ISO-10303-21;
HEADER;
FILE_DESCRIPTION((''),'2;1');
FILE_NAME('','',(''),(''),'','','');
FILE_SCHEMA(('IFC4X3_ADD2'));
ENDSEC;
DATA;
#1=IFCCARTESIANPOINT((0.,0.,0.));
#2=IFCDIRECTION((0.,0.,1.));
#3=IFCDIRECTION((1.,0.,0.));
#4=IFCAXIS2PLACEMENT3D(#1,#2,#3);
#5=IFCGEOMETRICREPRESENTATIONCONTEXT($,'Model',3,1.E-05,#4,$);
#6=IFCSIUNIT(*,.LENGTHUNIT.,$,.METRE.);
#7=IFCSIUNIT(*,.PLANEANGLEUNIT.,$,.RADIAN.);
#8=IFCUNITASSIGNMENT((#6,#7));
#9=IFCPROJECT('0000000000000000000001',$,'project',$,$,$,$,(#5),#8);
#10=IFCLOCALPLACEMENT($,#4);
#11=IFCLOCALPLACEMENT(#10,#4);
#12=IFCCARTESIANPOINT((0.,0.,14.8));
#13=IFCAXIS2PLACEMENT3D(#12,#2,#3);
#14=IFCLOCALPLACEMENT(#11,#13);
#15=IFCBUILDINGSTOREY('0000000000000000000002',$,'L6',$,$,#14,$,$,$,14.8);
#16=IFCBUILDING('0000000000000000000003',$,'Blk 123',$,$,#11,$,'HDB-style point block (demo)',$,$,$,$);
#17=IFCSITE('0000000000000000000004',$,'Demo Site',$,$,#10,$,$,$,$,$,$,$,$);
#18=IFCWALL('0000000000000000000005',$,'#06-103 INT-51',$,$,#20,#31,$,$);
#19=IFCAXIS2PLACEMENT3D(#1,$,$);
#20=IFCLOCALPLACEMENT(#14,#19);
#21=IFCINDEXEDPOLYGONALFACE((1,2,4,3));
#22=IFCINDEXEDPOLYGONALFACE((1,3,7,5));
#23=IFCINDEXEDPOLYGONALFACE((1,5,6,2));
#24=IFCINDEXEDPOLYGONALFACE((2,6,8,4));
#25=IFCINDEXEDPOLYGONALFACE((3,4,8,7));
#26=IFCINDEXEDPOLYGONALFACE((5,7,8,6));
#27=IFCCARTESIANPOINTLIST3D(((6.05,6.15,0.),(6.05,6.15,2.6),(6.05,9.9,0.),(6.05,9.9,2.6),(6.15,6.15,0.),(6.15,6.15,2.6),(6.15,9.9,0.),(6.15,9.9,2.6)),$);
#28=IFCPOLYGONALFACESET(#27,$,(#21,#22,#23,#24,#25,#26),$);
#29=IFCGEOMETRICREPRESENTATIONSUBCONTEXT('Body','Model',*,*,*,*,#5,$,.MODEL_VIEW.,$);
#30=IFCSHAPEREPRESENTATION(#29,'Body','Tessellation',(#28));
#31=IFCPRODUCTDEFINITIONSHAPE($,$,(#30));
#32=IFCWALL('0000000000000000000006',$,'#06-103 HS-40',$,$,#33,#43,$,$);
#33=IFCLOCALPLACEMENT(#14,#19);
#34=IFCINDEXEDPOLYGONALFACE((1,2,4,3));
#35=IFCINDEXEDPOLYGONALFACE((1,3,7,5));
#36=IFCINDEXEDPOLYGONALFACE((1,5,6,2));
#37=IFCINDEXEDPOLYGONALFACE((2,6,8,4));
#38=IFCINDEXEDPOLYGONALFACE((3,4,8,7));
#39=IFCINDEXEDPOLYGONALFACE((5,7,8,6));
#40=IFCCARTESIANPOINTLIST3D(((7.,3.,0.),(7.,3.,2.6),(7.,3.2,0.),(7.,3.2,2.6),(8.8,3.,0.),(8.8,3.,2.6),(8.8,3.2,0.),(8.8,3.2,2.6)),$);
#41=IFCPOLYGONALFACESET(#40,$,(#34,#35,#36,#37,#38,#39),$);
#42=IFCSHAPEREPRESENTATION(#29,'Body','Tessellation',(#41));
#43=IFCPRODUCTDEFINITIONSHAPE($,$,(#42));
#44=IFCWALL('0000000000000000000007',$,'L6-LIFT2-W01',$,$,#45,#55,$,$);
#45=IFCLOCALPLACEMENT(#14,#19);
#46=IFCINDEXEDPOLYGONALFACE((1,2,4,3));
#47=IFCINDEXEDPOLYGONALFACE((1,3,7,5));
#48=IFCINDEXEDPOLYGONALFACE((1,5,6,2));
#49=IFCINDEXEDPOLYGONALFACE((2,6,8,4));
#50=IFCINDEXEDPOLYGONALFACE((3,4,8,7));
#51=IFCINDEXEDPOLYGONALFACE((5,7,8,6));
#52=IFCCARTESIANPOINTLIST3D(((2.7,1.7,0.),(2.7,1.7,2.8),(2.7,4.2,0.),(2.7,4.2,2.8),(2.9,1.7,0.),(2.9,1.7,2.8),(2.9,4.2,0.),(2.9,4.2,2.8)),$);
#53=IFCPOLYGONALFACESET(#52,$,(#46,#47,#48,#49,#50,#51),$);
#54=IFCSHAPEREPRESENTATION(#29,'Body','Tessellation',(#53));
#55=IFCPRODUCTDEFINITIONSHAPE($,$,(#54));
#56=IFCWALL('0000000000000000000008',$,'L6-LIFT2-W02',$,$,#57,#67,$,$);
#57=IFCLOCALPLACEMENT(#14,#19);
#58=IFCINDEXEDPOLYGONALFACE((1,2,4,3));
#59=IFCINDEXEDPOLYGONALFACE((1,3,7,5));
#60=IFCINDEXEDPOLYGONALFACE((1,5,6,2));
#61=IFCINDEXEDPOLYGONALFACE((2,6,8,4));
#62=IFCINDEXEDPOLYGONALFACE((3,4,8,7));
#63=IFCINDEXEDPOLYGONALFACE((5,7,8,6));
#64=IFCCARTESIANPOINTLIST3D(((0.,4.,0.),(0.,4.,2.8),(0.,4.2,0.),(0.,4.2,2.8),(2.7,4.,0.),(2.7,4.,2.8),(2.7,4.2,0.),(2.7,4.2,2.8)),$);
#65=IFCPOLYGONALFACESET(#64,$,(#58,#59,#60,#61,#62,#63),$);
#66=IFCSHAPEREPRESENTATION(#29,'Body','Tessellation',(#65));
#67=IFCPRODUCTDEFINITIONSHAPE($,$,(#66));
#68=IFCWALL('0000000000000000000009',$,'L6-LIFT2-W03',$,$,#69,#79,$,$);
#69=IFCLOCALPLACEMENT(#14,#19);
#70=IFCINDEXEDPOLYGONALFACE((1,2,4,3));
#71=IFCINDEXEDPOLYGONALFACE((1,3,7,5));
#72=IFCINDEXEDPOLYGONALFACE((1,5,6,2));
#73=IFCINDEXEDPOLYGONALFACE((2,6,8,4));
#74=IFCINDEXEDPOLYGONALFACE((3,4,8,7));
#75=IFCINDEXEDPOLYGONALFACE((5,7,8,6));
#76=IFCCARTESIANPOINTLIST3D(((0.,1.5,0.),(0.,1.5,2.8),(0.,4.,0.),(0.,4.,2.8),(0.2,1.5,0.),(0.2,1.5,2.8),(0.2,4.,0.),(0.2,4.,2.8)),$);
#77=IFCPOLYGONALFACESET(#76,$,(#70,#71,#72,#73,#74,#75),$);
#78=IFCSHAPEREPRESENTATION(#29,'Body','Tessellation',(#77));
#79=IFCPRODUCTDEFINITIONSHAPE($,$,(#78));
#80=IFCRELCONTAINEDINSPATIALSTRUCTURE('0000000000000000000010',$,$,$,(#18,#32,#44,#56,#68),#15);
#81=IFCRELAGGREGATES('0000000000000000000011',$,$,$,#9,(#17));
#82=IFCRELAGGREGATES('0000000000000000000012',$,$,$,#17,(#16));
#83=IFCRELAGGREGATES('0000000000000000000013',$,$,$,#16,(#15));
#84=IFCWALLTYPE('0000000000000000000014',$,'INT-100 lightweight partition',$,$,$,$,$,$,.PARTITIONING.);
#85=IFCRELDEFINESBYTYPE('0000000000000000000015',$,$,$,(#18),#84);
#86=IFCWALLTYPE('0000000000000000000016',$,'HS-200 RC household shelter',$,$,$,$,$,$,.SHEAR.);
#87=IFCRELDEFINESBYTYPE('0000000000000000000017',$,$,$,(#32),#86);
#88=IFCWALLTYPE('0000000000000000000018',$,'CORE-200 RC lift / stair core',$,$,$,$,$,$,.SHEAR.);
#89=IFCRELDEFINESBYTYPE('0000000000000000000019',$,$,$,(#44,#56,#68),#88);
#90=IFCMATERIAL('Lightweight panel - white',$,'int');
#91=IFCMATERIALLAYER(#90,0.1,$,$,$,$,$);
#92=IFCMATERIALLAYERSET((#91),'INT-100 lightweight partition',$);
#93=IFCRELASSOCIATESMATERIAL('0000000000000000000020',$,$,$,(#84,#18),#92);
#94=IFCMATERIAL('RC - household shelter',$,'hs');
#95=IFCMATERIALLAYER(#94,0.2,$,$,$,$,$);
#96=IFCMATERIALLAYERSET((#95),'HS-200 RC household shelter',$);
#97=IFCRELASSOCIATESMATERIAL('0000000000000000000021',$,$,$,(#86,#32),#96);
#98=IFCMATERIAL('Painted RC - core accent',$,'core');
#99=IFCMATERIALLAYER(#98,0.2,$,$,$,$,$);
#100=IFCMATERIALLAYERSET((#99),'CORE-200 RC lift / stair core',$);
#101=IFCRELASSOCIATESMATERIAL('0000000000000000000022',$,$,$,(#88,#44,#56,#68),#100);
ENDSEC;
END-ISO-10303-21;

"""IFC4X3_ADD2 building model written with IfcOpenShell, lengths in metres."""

from ifc_helpers import new_model, si_unit, frame, origin_with_axes, place, context, subcontext, project, spatial, indexed_curve, outline, extrude, material, layer, layer_set, layer_usage, type_object, element, save


model = new_model("IFC4X3_ADD2")

# Units and contexts
model_context = context("Model", 3, precision=1e-05, world=origin_with_axes())
body_context = subcontext(model_context, "Body", "Model", "MODEL_VIEW")
ifc_project = project(units=[si_unit("LENGTHUNIT", "METRE"), si_unit("PLANEANGLEUNIT", "RADIAN")], contexts=[model_context])

# Site, building, storey
site_placement = place(None, origin_with_axes())
site = spatial("IfcSite", under=ifc_project, at=site_placement, Name="Demo Site")
building_placement = place(site_placement, origin_with_axes())
building = spatial("IfcBuilding", under=site, at=building_placement, Name="Blk 123", LongName="HDB-style point block (demo)")
storey_placement = place(building_placement, frame((0.0, 0.0, 14.8), z_axis=(0.0, 0.0, 1.0), x_axis=(1.0, 0.0, 0.0)))
storey = spatial("IfcBuildingStorey", under=building, at=storey_placement, Name="L6", Elevation=14.8)

# Shared definitions
ifc_material_1 = material(Name="Lightweight panel - white", Category="int")
ifc_layer_1 = layer(ifc_material_1, 0.1)
ifc_layer_set_1 = layer_set([ifc_layer_1], Name="INT-100 lightweight partition")
ifc_layer_usage_1 = layer_usage(ifc_layer_set_1, "AXIS2", "POSITIVE", -0.05)
wall_type_1 = type_object("IfcWallType", Name="INT-100 lightweight partition", PredefinedType="PARTITIONING", material=ifc_layer_set_1)

# Walls
wall_1_placement = place(storey_placement, frame((6.1, 6.15, 0.0), z_axis=(0.0, 0.0, 1.0), x_axis=(0.0, 1.0, 0.0)))
element("IfcWall", 1, at=wall_1_placement, inside=storey, type_object=wall_type_1, material=ifc_layer_usage_1, Name="#06-103 INT-51", context=body_context, shape_type="SweptSolid", body=[
    extrude(outline(indexed_curve([(0.0, 0.0), (0.0, 0.1), (3.75, 0.1), (3.75, 0.0), (0.0, 0.0)], self_intersect=False)), frame((0.0, -0.05, 0.0), z_axis=(0.0, 0.0, 1.0), x_axis=(1.0, 0.0, 0.0)), (0.0, 0.0, 1.0), 2.6),
])
ifc_material_2 = material(Name="RC - household shelter", Category="hs")
ifc_layer_2 = layer(ifc_material_2, 0.2)
ifc_layer_set_2 = layer_set([ifc_layer_2], Name="HS-200 RC household shelter")
ifc_layer_usage_2 = layer_usage(ifc_layer_set_2, "AXIS2", "POSITIVE", -0.1)
wall_type_2 = type_object("IfcWallType", Name="HS-200 RC household shelter", PredefinedType="SHEAR", material=ifc_layer_set_2)
wall_2_placement = place(storey_placement, frame((7.0, 3.1, 0.0), z_axis=(0.0, 0.0, 1.0), x_axis=(1.0, 0.0, 0.0)))
element("IfcWall", 2, at=wall_2_placement, inside=storey, type_object=wall_type_2, material=ifc_layer_usage_2, Name="#06-103 HS-40", context=body_context, shape_type="SweptSolid", body=[
    extrude(outline(indexed_curve([(0.0, 0.0), (0.0, 0.2), (1.8, 0.2), (1.8, 0.0), (0.0, 0.0)], self_intersect=False)), frame((0.0, -0.1, 0.0), z_axis=(0.0, 0.0, 1.0), x_axis=(1.0, 0.0, 0.0)), (0.0, 0.0, 1.0), 2.6),
])
ifc_material_3 = material(Name="Painted RC - core accent", Category="core")
ifc_layer_3 = layer(ifc_material_3, 0.2)
ifc_layer_set_3 = layer_set([ifc_layer_3], Name="CORE-200 RC lift / stair core")
ifc_layer_usage_3 = layer_usage(ifc_layer_set_3, "AXIS2", "POSITIVE", 0.0)
wall_type_3 = type_object("IfcWallType", Name="CORE-200 RC lift / stair core", PredefinedType="SHEAR", material=ifc_layer_set_3)
wall_3_placement = place(storey_placement, frame((2.9, 1.7, 0.0), z_axis=(0.0, 0.0, 1.0), x_axis=(0.0, 1.0, 0.0)))
element("IfcWall", 3, at=wall_3_placement, inside=storey, type_object=wall_type_3, material=ifc_layer_usage_3, Name="L6-LIFT2-W01", context=body_context, shape_type="SweptSolid", body=[
    extrude(outline(indexed_curve([(0.0, 0.0), (0.0, 0.2), (2.5, 0.2), (2.5, 0.0), (0.0, 0.0)], self_intersect=False)), origin_with_axes(), (0.0, 0.0, 1.0), 2.8),
])
wall_4_placement = place(storey_placement, frame((2.7, 4.2, 0.0), z_axis=(0.0, 0.0, 1.0), x_axis=(-1.0, 0.0, 0.0)))
element("IfcWall", 4, at=wall_4_placement, inside=storey, type_object=wall_type_3, material=ifc_layer_usage_3, Name="L6-LIFT2-W02", context=body_context, shape_type="SweptSolid", body=[
    extrude(outline(indexed_curve([(0.0, 0.0), (0.0, 0.2), (2.7, 0.2), (2.7, 0.0), (0.0, 0.0)], self_intersect=False)), origin_with_axes(), (0.0, 0.0, 1.0), 2.8),
])
wall_5_placement = place(storey_placement, frame((0.0, 4.0, 0.0), z_axis=(0.0, 0.0, 1.0), x_axis=(0.0, -1.0, 0.0)))
element("IfcWall", 5, at=wall_5_placement, inside=storey, type_object=wall_type_3, material=ifc_layer_usage_3, Name="L6-LIFT2-W03", context=body_context, shape_type="SweptSolid", body=[
    extrude(outline(indexed_curve([(0.0, 0.0), (0.0, 0.2), (2.5, 0.2), (2.5, 0.0), (0.0, 0.0)], self_intersect=False)), origin_with_axes(), (0.0, 0.0, 1.0), 2.8),
])

save(model, "model.ifc")
